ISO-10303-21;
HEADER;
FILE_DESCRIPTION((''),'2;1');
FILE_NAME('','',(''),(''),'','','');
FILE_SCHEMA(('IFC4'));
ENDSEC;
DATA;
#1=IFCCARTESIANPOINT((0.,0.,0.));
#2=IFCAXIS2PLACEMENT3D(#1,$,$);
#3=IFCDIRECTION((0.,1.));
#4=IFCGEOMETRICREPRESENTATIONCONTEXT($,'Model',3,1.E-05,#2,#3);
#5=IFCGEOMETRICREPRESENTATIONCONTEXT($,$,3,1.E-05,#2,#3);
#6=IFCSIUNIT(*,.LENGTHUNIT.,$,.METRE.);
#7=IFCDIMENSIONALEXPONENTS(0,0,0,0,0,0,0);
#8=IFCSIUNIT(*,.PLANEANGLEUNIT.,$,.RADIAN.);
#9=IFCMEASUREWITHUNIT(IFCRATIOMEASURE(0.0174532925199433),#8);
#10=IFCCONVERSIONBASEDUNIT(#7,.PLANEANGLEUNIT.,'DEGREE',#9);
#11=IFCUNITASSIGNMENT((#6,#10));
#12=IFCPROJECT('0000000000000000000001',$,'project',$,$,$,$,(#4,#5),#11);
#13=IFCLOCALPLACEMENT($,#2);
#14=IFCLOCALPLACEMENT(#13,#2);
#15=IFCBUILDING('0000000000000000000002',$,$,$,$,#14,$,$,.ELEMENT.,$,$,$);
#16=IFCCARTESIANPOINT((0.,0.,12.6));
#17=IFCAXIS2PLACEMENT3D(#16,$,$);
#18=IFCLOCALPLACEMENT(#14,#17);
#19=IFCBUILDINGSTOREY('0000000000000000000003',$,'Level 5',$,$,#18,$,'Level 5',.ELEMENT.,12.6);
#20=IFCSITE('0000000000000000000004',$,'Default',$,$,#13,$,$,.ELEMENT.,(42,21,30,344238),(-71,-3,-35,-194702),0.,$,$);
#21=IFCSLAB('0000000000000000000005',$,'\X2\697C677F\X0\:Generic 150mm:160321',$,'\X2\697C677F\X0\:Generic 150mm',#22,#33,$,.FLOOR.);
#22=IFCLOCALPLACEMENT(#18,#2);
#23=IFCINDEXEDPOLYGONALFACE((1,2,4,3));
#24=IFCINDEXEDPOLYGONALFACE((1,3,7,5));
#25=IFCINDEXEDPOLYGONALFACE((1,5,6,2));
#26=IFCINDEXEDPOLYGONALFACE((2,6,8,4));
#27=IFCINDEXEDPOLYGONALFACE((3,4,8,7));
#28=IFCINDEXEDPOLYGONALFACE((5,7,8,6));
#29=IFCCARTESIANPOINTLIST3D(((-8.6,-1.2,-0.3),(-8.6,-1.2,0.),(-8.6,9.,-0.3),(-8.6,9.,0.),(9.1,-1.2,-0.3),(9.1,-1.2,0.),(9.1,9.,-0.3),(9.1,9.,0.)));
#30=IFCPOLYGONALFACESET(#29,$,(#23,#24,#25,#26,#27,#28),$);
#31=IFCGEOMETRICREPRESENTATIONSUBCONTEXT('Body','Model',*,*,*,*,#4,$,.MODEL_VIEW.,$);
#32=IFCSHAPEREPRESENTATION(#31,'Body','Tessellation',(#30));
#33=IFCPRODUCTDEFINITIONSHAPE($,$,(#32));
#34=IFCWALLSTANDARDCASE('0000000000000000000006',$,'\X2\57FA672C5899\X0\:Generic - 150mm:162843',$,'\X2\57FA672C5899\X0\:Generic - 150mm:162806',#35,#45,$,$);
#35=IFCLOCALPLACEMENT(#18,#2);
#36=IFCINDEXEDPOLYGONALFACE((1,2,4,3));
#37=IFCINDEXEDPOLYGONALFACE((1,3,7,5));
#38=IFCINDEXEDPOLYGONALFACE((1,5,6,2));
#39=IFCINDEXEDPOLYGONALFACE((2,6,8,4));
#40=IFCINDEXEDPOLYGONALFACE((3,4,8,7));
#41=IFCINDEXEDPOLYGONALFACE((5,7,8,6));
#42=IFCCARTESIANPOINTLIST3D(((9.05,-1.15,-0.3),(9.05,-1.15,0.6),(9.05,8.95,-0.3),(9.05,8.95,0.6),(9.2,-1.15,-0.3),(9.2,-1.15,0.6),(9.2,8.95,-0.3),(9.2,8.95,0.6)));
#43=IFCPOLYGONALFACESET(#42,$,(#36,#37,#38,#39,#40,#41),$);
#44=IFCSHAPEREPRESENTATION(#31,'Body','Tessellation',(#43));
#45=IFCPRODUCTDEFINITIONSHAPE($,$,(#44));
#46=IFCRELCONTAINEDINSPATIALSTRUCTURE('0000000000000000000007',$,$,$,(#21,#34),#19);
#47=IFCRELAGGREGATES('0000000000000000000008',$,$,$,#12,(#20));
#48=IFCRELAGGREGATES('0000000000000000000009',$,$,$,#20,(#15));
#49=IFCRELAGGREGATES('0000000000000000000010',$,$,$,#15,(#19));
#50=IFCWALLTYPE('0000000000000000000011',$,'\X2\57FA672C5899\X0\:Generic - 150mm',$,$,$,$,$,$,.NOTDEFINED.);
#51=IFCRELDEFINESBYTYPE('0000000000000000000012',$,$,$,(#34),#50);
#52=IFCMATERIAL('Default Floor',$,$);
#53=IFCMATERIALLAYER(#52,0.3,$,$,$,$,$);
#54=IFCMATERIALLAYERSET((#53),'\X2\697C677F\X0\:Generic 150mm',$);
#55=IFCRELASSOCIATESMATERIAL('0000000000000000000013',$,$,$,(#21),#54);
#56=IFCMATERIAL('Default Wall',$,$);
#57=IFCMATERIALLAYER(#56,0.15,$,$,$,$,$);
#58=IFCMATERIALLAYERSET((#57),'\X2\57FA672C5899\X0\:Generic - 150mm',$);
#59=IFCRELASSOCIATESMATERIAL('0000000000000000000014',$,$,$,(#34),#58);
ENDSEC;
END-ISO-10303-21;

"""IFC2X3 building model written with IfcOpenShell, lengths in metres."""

from ifc_helpers import new_model, entity, si_unit, converted_unit, direction, frame, frame_2d, origin, place, context, subcontext, project, spatial, rectangle, extrude, material, layer, layer_set, layer_usage, type_object, element, save


model = new_model("IFC2X3")

# Units and contexts
model_context = context("Model", 3, precision=1e-05, world=origin(), true_north=direction((0.0, 1.0)))
context_of_model = context(None, 3, precision=1e-05, world=origin(), true_north=direction((0.0, 1.0)))
body_context = subcontext(model_context, "Body", "Model", "MODEL_VIEW")
ifc_project = project(units=[si_unit("LENGTHUNIT", "METRE"), converted_unit("PLANEANGLEUNIT", "DEGREE", entity("IfcRatioMeasure", 0.0174532925199433), si_unit("PLANEANGLEUNIT", "RADIAN"), dimensions=[0, 0, 0, 0, 0, 0, 0])], contexts=[model_context, context_of_model])

# Site, building, storey
site_placement = place(None, origin())
site = spatial("IfcSite", under=ifc_project, at=site_placement, Name="Default", CompositionType="ELEMENT", RefLatitude=(42, 21, 30, 344238), RefLongitude=(-71, -3, -35, -194702), RefElevation=0.0)
building_placement = place(site_placement, origin())
building = spatial("IfcBuilding", under=site, at=building_placement, CompositionType="ELEMENT")
storey_placement = place(building_placement, frame((0.0, 0.0, 12.6)))
storey = spatial("IfcBuildingStorey", under=building, at=storey_placement, Name="Level 5", LongName="Level 5", CompositionType="ELEMENT", Elevation=12.6)

# Slab
ifc_material_1 = material(Name="Default Floor")
ifc_layer_1 = layer(ifc_material_1, 0.3)
ifc_layer_set_1 = layer_set([ifc_layer_1], Name="楼板:Generic 150mm")
ifc_layer_usage_1 = layer_usage(ifc_layer_set_1, "AXIS3", "POSITIVE", 0.0)
slab_placement = place(storey_placement, origin())
element("IfcSlab", 1, at=slab_placement, inside=storey, material=ifc_layer_usage_1, Name="楼板:Generic 150mm:160321", ObjectType="楼板:Generic 150mm", PredefinedType="FLOOR", context=body_context, shape_type="SweptSolid", body=[
    extrude(rectangle(XDim=10.2, YDim=17.7, at=frame_2d((0.0, 0.0), x_axis=(1.0, 0.0))), frame((0.25, 3.9, 0.0), z_axis=(0.0, 0.0, -1.0), x_axis=(0.0, 1.0, 0.0)), (0.0, 0.0, 1.0), 0.3),
])

# Wall
ifc_material_2 = material(Name="Default Wall")
ifc_layer_2 = layer(ifc_material_2, 0.15)
ifc_layer_set_2 = layer_set([ifc_layer_2], Name="基本墙:Generic - 150mm")
wall_type = type_object("IfcWallType", Name="基本墙:Generic - 150mm", PredefinedType="NOTDEFINED")
ifc_layer_usage_2 = layer_usage(ifc_layer_set_2, "AXIS2", "NEGATIVE", 0.075)
wall_1_placement = place(storey_placement, frame((9.125, 8.95, -0.3), z_axis=(0.0, 0.0, 1.0), x_axis=(0.0, -1.0, 0.0)))
element("IfcWallStandardCase", 2, at=wall_1_placement, inside=storey, type_object=wall_type, material=ifc_layer_usage_2, Name="基本墙:Generic - 150mm:162843", ObjectType="基本墙:Generic - 150mm:162806", context=body_context, shape_type="SweptSolid", body=[
    extrude(rectangle(XDim=10.1, YDim=0.15, at=frame_2d((5.05, 0.0), x_axis=(1.0, 0.0))), origin(), (0.0, 0.0, 1.0), 0.9),
])

save(model, "model.ifc")
